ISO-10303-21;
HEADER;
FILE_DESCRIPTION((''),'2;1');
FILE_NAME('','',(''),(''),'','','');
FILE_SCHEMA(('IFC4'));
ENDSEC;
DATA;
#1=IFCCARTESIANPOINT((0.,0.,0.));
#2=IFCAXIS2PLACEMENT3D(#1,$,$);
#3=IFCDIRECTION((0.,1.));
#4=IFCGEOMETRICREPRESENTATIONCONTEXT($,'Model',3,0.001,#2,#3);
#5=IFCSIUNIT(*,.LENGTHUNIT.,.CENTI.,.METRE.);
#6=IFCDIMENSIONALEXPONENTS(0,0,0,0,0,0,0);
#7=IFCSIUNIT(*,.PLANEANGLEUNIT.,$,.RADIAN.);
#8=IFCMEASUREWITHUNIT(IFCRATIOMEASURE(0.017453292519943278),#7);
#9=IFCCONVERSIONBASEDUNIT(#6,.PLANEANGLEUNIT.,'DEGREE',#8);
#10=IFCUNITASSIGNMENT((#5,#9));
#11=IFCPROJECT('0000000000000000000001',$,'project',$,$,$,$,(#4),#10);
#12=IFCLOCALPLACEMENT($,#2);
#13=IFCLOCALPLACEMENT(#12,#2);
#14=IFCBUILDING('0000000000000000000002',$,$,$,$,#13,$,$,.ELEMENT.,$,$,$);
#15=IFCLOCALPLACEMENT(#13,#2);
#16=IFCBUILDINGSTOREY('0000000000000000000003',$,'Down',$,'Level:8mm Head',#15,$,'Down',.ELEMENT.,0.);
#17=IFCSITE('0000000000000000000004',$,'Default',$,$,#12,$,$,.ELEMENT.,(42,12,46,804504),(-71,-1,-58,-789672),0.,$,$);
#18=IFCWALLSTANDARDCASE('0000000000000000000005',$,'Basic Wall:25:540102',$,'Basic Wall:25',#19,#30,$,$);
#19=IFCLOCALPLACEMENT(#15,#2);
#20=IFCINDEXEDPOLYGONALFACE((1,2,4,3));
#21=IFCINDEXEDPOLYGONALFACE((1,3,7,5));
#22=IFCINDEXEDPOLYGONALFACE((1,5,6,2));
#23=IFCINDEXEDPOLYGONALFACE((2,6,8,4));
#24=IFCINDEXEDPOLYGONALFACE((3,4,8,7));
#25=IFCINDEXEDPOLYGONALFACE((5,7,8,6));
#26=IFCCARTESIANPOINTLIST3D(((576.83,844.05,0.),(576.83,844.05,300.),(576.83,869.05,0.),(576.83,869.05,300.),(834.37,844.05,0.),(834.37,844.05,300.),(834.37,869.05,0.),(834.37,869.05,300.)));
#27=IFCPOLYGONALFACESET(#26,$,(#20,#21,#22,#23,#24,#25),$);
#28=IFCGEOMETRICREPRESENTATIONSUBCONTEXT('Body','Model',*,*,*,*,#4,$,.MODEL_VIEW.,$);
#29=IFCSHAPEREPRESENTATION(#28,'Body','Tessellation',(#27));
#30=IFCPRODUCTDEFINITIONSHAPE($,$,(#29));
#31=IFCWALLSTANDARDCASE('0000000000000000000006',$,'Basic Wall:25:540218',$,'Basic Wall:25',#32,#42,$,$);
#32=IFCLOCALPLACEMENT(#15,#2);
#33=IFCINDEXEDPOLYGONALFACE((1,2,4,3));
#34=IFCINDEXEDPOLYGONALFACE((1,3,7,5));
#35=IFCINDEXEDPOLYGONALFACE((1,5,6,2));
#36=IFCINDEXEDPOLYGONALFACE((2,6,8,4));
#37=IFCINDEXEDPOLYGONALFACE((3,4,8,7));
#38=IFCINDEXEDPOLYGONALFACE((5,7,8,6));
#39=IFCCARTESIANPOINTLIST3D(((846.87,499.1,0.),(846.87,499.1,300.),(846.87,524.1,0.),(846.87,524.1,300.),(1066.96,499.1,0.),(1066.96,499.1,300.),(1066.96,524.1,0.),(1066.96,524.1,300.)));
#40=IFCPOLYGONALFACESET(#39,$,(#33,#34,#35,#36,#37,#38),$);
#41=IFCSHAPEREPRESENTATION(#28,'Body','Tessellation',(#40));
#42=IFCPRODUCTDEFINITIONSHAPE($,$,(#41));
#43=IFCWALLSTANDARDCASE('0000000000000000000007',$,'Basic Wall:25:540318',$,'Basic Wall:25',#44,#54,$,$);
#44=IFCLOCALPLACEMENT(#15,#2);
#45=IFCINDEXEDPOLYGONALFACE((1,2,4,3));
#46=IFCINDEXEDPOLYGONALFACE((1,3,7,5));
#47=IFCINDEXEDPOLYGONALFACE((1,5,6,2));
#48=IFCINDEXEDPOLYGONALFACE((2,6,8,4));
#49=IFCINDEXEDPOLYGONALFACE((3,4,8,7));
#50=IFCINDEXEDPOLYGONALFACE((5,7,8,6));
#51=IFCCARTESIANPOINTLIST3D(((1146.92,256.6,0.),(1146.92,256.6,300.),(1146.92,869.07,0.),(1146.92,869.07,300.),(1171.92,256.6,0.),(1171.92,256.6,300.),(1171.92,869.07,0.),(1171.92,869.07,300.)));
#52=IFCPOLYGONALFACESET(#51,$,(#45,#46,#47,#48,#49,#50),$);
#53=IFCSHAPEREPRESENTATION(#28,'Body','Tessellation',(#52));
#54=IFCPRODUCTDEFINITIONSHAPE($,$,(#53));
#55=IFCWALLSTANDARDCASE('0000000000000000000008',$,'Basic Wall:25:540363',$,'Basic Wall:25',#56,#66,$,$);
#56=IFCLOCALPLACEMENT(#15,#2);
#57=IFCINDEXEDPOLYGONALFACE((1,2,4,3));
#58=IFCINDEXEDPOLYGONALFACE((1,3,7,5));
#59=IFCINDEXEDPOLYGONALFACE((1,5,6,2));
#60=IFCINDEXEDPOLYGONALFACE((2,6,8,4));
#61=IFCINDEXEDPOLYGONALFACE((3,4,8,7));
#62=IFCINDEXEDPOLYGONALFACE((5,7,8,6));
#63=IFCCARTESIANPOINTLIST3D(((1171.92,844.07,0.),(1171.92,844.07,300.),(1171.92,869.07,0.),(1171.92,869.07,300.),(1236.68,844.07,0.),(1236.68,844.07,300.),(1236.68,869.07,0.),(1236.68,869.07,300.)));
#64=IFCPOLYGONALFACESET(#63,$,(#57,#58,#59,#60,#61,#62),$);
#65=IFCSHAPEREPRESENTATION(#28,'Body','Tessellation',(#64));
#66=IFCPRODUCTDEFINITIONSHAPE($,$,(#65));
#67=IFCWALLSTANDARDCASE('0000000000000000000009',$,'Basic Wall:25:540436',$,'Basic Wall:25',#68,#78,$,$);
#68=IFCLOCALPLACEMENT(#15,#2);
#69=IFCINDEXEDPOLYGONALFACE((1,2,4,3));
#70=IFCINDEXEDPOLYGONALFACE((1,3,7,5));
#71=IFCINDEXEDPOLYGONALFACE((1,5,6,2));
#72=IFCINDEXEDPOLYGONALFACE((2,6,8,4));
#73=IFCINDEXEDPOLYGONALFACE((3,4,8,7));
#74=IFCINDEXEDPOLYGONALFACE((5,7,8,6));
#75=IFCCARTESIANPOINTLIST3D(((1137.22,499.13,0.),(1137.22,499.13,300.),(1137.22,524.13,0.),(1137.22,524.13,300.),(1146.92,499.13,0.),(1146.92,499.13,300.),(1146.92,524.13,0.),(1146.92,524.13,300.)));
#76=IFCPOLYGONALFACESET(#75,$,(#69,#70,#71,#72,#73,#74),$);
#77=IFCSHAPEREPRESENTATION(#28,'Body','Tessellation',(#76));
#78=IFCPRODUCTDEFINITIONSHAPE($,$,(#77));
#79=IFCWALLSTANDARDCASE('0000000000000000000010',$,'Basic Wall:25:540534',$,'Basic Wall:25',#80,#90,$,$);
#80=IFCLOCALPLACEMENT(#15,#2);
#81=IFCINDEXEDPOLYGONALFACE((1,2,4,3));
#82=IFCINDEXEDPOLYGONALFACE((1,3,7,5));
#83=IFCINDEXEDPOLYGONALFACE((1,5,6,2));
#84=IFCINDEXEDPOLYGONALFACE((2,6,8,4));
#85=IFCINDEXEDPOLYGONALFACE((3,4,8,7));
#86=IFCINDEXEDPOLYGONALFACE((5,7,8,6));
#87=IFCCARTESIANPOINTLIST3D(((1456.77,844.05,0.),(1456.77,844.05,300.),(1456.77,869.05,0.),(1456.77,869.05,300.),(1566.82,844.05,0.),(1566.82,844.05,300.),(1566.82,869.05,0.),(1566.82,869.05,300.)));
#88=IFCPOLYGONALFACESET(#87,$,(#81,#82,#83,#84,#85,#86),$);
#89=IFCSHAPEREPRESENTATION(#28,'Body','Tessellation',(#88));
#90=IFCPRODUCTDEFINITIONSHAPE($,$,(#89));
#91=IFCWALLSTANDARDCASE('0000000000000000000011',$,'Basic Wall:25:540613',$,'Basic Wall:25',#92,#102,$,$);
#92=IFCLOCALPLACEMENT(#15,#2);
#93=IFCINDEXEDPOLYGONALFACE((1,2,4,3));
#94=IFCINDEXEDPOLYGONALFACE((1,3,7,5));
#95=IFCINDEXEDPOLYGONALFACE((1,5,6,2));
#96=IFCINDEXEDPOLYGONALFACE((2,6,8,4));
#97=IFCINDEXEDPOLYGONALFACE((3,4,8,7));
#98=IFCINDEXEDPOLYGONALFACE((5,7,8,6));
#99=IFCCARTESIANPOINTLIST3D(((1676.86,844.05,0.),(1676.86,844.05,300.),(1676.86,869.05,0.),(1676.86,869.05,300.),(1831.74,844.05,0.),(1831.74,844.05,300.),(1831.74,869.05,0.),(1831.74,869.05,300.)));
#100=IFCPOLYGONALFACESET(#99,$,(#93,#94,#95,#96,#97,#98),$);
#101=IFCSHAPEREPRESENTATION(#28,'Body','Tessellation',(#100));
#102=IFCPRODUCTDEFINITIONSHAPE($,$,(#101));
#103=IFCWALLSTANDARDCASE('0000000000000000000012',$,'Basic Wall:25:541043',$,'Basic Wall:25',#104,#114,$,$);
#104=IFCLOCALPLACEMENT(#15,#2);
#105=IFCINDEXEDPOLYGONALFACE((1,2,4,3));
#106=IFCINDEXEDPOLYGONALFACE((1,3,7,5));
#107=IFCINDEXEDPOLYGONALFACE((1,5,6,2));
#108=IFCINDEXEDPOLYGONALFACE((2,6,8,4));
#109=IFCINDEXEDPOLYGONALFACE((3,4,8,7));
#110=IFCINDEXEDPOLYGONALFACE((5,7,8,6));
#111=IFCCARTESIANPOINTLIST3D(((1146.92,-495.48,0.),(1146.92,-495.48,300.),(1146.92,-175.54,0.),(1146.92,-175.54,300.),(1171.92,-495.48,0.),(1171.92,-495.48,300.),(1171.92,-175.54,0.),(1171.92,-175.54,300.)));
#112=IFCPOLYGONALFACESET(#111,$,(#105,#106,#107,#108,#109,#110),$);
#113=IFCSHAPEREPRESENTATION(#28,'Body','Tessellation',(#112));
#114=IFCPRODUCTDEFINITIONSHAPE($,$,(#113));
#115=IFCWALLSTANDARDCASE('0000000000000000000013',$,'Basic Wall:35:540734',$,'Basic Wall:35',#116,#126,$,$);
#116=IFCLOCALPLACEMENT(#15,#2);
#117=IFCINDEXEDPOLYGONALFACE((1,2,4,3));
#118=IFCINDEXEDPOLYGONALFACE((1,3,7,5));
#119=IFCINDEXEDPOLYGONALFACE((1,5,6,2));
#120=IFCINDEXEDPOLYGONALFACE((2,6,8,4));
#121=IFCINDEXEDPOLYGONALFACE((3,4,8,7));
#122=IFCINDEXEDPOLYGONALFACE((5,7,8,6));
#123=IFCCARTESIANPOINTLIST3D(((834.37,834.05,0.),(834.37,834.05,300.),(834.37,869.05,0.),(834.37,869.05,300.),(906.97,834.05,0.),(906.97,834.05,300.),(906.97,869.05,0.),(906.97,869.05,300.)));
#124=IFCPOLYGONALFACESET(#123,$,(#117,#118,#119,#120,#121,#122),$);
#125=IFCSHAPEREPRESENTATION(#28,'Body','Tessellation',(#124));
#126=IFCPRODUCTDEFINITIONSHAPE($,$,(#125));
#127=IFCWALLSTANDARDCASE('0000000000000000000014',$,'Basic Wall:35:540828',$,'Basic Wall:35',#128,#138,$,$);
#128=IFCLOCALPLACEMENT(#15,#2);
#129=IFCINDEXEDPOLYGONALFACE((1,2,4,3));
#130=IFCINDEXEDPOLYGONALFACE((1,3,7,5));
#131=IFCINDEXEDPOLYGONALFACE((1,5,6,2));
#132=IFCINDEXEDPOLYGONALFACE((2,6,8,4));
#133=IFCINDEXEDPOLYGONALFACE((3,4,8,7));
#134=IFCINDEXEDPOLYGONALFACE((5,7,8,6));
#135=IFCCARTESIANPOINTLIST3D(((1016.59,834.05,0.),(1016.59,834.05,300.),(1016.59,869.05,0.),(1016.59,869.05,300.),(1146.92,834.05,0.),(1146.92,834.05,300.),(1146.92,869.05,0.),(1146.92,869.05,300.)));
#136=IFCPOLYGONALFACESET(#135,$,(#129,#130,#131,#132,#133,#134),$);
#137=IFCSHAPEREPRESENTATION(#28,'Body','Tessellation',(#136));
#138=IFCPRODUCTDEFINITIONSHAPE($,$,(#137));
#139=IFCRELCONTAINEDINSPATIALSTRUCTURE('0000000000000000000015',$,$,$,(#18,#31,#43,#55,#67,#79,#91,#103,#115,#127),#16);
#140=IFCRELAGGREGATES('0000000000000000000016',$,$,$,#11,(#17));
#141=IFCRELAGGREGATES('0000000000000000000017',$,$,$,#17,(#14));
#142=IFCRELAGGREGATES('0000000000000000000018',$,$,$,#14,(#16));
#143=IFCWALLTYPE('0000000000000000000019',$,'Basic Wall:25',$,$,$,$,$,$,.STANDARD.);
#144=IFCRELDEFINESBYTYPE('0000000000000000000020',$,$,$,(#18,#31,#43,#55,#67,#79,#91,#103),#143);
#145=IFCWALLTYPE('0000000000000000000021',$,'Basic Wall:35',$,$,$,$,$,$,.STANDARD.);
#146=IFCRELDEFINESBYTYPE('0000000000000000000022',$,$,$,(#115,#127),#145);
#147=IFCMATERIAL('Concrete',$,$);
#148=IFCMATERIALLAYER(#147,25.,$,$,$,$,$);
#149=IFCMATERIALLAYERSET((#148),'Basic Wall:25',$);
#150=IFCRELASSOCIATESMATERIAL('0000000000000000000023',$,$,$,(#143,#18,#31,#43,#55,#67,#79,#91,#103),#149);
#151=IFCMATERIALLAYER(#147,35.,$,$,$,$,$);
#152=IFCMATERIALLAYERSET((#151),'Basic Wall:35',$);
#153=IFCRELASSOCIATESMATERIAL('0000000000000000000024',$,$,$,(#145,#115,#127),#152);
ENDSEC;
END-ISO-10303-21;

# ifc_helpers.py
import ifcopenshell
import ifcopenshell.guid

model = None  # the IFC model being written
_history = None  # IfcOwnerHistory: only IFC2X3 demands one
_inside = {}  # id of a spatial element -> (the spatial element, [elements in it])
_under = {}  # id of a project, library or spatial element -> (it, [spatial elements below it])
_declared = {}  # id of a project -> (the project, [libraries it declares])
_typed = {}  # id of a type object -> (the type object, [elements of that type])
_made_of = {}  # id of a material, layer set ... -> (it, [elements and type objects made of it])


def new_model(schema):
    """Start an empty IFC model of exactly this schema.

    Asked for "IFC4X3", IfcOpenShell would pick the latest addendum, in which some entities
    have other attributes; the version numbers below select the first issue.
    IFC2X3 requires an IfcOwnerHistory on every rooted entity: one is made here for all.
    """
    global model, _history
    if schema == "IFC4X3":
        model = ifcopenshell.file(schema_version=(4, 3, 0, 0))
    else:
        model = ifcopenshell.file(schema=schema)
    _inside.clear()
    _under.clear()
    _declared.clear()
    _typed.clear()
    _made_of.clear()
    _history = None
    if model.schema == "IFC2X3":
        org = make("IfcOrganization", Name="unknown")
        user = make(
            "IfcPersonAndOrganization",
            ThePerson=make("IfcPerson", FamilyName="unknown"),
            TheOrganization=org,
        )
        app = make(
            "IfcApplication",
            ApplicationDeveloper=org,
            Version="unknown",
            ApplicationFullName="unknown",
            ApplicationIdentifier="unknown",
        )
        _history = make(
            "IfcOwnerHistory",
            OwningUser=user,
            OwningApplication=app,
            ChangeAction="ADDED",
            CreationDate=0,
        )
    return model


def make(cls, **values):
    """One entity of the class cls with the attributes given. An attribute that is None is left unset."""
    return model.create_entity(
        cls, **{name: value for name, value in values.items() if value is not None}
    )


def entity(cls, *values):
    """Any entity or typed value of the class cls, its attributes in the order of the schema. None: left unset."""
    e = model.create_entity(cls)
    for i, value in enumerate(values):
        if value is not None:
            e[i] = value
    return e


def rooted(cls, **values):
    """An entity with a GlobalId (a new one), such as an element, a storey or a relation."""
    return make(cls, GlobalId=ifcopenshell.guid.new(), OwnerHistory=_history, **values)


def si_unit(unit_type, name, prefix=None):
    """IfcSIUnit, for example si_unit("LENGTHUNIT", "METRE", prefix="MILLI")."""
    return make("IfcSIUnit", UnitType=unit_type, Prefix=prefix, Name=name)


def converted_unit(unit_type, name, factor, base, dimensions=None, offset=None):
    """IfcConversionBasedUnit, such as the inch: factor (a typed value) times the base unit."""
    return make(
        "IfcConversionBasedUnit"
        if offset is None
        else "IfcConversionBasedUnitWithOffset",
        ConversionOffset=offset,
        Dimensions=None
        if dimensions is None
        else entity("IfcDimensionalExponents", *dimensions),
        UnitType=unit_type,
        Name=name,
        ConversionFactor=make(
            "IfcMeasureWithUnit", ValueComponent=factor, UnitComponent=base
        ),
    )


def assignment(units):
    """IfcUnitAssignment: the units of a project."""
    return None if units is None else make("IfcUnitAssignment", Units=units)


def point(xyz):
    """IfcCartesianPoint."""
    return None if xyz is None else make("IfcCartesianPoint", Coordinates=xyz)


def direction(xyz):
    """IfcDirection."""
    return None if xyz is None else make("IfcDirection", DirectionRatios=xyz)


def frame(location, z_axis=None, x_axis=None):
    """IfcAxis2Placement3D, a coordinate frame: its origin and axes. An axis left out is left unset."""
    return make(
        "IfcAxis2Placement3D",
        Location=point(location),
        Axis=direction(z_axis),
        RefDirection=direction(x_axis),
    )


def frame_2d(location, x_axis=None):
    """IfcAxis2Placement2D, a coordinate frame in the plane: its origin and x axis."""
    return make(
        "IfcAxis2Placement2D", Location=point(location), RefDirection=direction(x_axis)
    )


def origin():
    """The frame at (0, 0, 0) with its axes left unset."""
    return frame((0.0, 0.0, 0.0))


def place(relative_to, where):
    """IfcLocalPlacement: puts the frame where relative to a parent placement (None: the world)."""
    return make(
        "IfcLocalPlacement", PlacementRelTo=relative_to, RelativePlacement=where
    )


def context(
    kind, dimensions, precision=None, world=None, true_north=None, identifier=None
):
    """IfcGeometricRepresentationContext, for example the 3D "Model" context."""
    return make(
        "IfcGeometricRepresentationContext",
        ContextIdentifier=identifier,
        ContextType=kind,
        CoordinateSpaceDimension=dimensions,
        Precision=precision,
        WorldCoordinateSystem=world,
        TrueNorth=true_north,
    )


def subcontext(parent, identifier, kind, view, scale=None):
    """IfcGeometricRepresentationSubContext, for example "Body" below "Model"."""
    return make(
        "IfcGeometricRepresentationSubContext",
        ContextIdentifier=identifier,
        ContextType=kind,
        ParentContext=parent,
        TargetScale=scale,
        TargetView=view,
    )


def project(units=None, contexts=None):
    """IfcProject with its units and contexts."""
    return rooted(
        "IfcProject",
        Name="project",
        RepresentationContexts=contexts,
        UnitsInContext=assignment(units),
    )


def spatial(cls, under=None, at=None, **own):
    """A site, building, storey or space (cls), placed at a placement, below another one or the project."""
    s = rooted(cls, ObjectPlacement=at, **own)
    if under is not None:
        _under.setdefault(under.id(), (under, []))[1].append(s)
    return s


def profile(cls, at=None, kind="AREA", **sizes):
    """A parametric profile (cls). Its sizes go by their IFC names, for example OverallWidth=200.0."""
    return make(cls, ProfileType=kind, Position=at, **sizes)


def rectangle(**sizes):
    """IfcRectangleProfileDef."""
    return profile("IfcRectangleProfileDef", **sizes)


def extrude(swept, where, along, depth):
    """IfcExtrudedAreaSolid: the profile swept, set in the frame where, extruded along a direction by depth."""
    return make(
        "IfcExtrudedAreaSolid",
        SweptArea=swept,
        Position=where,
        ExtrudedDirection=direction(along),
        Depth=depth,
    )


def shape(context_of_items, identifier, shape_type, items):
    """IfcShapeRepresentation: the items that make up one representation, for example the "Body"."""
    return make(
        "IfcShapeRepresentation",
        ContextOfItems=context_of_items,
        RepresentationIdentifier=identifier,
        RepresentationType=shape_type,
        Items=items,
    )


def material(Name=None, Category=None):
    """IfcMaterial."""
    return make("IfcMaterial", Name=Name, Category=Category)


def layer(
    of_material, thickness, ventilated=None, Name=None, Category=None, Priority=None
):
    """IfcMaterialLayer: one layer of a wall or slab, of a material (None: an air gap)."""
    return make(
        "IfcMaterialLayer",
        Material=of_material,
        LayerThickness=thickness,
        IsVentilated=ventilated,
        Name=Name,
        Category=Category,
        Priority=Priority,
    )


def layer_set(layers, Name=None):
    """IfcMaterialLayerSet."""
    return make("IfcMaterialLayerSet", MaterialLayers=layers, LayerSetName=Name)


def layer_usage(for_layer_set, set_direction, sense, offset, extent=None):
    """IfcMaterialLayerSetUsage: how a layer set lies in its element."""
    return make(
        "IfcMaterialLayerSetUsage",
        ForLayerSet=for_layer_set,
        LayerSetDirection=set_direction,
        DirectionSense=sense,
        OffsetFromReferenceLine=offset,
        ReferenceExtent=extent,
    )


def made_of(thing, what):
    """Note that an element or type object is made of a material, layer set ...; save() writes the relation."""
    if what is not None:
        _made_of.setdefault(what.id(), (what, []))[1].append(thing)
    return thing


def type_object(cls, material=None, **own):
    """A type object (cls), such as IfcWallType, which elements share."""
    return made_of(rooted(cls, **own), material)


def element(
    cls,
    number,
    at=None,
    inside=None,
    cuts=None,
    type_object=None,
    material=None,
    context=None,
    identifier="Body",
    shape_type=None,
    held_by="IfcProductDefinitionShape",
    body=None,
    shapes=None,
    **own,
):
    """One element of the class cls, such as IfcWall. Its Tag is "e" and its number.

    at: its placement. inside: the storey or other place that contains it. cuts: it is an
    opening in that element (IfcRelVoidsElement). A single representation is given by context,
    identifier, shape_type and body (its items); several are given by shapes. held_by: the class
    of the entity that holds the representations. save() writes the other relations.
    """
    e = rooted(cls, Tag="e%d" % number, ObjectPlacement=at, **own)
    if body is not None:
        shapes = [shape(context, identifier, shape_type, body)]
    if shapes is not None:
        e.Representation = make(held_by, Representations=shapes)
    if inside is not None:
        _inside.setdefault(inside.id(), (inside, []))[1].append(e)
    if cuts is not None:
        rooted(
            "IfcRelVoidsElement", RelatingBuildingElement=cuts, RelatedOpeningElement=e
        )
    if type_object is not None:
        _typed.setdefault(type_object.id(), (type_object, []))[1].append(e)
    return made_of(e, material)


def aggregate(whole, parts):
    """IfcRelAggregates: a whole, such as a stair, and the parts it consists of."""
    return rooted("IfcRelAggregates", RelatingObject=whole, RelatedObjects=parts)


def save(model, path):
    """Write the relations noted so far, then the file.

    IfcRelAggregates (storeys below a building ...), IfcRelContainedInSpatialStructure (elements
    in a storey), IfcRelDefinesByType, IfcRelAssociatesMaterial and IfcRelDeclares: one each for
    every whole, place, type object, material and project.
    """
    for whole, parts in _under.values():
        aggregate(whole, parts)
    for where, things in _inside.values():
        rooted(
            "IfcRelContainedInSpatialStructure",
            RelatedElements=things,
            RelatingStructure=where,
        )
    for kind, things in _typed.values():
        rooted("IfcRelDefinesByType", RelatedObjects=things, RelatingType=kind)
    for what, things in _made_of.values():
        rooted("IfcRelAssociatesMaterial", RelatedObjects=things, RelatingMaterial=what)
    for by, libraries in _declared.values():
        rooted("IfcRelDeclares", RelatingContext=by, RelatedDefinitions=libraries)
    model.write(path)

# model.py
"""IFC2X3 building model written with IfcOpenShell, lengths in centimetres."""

from ifc_helpers import new_model, entity, si_unit, converted_unit, direction, frame, frame_2d, origin, place, context, subcontext, project, spatial, rectangle, extrude, material, layer, layer_set, layer_usage, type_object, element, save


model = new_model("IFC2X3")

# Units and contexts
model_context = context("Model", 3, precision=0.001, world=origin(), true_north=direction((0.0, 1.0)))
body_context = subcontext(model_context, "Body", "Model", "MODEL_VIEW")
ifc_project = project(units=[si_unit("LENGTHUNIT", "METRE", prefix="CENTI"), converted_unit("PLANEANGLEUNIT", "DEGREE", entity("IfcRatioMeasure", 0.017453292519943278), si_unit("PLANEANGLEUNIT", "RADIAN"), dimensions=[0, 0, 0, 0, 0, 0, 0])], contexts=[model_context])

# Site, building, storey
site_placement = place(None, origin())
site = spatial("IfcSite", under=ifc_project, at=site_placement, Name="Default", CompositionType="ELEMENT", RefLatitude=(42, 12, 46, 804504), RefLongitude=(-71, -1, -58, -789672), RefElevation=0.0)
building_placement = place(site_placement, origin())
building = spatial("IfcBuilding", under=site, at=building_placement, CompositionType="ELEMENT")
storey_placement = place(building_placement, origin())
storey = spatial("IfcBuildingStorey", under=building, at=storey_placement, Name="Down", ObjectType="Level:8mm Head", LongName="Down", CompositionType="ELEMENT", Elevation=0.0)

# Walls
ifc_material = material(Name="Concrete")
ifc_layer_1 = layer(ifc_material, 25.0)
ifc_layer_set_1 = layer_set([ifc_layer_1], Name="Basic Wall:25")
wall_type_1 = type_object("IfcWallType", Name="Basic Wall:25", PredefinedType="STANDARD", material=ifc_layer_set_1)
ifc_layer_usage_1 = layer_usage(ifc_layer_set_1, "AXIS2", "NEGATIVE", 12.5)
wall_1_placement = place(storey_placement, frame((576.83, 856.55, 0.0)))
element("IfcWallStandardCase", 1, at=wall_1_placement, inside=storey, type_object=wall_type_1, material=ifc_layer_usage_1, Name="Basic Wall:25:540102", ObjectType="Basic Wall:25", context=body_context, shape_type="SweptSolid", body=[
    extrude(rectangle(XDim=257.53, YDim=25.0, at=frame_2d((128.77, 0.0), x_axis=(-1.0, 0.0))), origin(), (0.0, 0.0, 1.0), 300.0),
])
ifc_layer_usage_2 = layer_usage(ifc_layer_set_1, "AXIS2", "NEGATIVE", 12.5)
wall_2_placement = place(storey_placement, frame((846.87, 511.6, 0.0)))
element("IfcWallStandardCase", 2, at=wall_2_placement, inside=storey, type_object=wall_type_1, material=ifc_layer_usage_2, Name="Basic Wall:25:540218", ObjectType="Basic Wall:25", context=body_context, shape_type="SweptSolid", body=[
    extrude(rectangle(XDim=220.09, YDim=25.0, at=frame_2d((110.05, 0.0), x_axis=(-1.0, 0.0))), origin(), (0.0, 0.0, 1.0), 300.0),
])
ifc_layer_usage_3 = layer_usage(ifc_layer_set_1, "AXIS2", "POSITIVE", -12.5)
wall_3_placement = place(storey_placement, frame((1159.42, 256.6, 0.0), z_axis=(0.0, 0.0, 1.0), x_axis=(0.0, 1.0, 0.0)))
element("IfcWallStandardCase", 3, at=wall_3_placement, inside=storey, type_object=wall_type_1, material=ifc_layer_usage_3, Name="Basic Wall:25:540318", ObjectType="Basic Wall:25", context=body_context, shape_type="SweptSolid", body=[
    extrude(rectangle(XDim=612.47, YDim=25.0, at=frame_2d((306.24, 0.0), x_axis=(-1.0, 0.0))), origin(), (0.0, 0.0, 1.0), 300.0),
])
ifc_layer_usage_4 = layer_usage(ifc_layer_set_1, "AXIS2", "POSITIVE", -12.5)
wall_4_placement = place(storey_placement, frame((1171.92, 856.57, 0.0)))
element("IfcWallStandardCase", 4, at=wall_4_placement, inside=storey, type_object=wall_type_1, material=ifc_layer_usage_4, Name="Basic Wall:25:540363", ObjectType="Basic Wall:25", context=body_context, shape_type="SweptSolid", body=[
    extrude(rectangle(XDim=64.76, YDim=25.0, at=frame_2d((32.38, 0.0), x_axis=(-1.0, 0.0))), origin(), (0.0, 0.0, 1.0), 300.0),
])
ifc_layer_usage_5 = layer_usage(ifc_layer_set_1, "AXIS2", "POSITIVE", -12.5)
wall_5_placement = place(storey_placement, frame((1137.22, 511.63, 0.0)))
element("IfcWallStandardCase", 5, at=wall_5_placement, inside=storey, type_object=wall_type_1, material=ifc_layer_usage_5, Name="Basic Wall:25:540436", ObjectType="Basic Wall:25", context=body_context, shape_type="SweptSolid", body=[
    extrude(rectangle(XDim=9.71, YDim=25.0, at=frame_2d((4.85, 0.0), x_axis=(-1.0, 0.0))), origin(), (0.0, 0.0, 1.0), 300.0),
])
ifc_layer_usage_6 = layer_usage(ifc_layer_set_1, "AXIS2", "NEGATIVE", 12.5)
wall_6_placement = place(storey_placement, frame((1456.77, 856.55, 0.0)))
element("IfcWallStandardCase", 6, at=wall_6_placement, inside=storey, type_object=wall_type_1, material=ifc_layer_usage_6, Name="Basic Wall:25:540534", ObjectType="Basic Wall:25", context=body_context, shape_type="SweptSolid", body=[
    extrude(rectangle(XDim=110.05, YDim=25.0, at=frame_2d((55.02, 0.0), x_axis=(-1.0, 0.0))), origin(), (0.0, 0.0, 1.0), 300.0),
])
ifc_layer_usage_7 = layer_usage(ifc_layer_set_1, "AXIS2", "NEGATIVE", 12.5)
wall_7_placement = place(storey_placement, frame((1676.86, 856.55, 0.0)))
element("IfcWallStandardCase", 7, at=wall_7_placement, inside=storey, type_object=wall_type_1, material=ifc_layer_usage_7, Name="Basic Wall:25:540613", ObjectType="Basic Wall:25", context=body_context, shape_type="SweptSolid", body=[
    extrude(rectangle(XDim=154.88, YDim=25.0, at=frame_2d((77.44, 0.0), x_axis=(-1.0, 0.0))), origin(), (0.0, 0.0, 1.0), 300.0),
])
ifc_layer_usage_8 = layer_usage(ifc_layer_set_1, "AXIS2", "POSITIVE", -12.5)
wall_8_placement = place(storey_placement, frame((1159.42, -495.48, 0.0), z_axis=(0.0, 0.0, 1.0), x_axis=(0.0, 1.0, 0.0)))
element("IfcWallStandardCase", 8, at=wall_8_placement, inside=storey, type_object=wall_type_1, material=ifc_layer_usage_8, Name="Basic Wall:25:541043", ObjectType="Basic Wall:25", context=body_context, shape_type="SweptSolid", body=[
    extrude(rectangle(XDim=319.95, YDim=25.0, at=frame_2d((159.97, 0.0), x_axis=(-1.0, 0.0))), origin(), (0.0, 0.0, 1.0), 300.0),
])
ifc_layer_2 = layer(ifc_material, 35.0)
ifc_layer_set_2 = layer_set([ifc_layer_2], Name="Basic Wall:35")
ifc_layer_usage_9 = layer_usage(ifc_layer_set_2, "AXIS2", "NEGATIVE", 17.5)
wall_type_2 = type_object("IfcWallType", Name="Basic Wall:35", PredefinedType="STANDARD", material=ifc_layer_set_2)
wall_9_placement = place(storey_placement, frame((834.37, 851.55, 0.0)))
element("IfcWallStandardCase", 9, at=wall_9_placement, inside=storey, type_object=wall_type_2, material=ifc_layer_usage_9, Name="Basic Wall:35:540734", ObjectType="Basic Wall:35", context=body_context, shape_type="SweptSolid", body=[
    extrude(rectangle(XDim=72.6, YDim=35.0, at=frame_2d((36.3, 0.0), x_axis=(-1.0, 0.0))), origin(), (0.0, 0.0, 1.0), 300.0),
])
ifc_layer_usage_10 = layer_usage(ifc_layer_set_2, "AXIS2", "NEGATIVE", 17.5)
wall_10_placement = place(storey_placement, frame((1016.59, 851.55, 0.0)))
element("IfcWallStandardCase", 10, at=wall_10_placement, inside=storey, type_object=wall_type_2, material=ifc_layer_usage_10, Name="Basic Wall:35:540828", ObjectType="Basic Wall:35", context=body_context, shape_type="SweptSolid", body=[
    extrude(rectangle(XDim=130.33, YDim=35.0, at=frame_2d((65.17, 0.0), x_axis=(-1.0, 0.0))), origin(), (0.0, 0.0, 1.0), 300.0),
])

save(model, "model.ifc")
